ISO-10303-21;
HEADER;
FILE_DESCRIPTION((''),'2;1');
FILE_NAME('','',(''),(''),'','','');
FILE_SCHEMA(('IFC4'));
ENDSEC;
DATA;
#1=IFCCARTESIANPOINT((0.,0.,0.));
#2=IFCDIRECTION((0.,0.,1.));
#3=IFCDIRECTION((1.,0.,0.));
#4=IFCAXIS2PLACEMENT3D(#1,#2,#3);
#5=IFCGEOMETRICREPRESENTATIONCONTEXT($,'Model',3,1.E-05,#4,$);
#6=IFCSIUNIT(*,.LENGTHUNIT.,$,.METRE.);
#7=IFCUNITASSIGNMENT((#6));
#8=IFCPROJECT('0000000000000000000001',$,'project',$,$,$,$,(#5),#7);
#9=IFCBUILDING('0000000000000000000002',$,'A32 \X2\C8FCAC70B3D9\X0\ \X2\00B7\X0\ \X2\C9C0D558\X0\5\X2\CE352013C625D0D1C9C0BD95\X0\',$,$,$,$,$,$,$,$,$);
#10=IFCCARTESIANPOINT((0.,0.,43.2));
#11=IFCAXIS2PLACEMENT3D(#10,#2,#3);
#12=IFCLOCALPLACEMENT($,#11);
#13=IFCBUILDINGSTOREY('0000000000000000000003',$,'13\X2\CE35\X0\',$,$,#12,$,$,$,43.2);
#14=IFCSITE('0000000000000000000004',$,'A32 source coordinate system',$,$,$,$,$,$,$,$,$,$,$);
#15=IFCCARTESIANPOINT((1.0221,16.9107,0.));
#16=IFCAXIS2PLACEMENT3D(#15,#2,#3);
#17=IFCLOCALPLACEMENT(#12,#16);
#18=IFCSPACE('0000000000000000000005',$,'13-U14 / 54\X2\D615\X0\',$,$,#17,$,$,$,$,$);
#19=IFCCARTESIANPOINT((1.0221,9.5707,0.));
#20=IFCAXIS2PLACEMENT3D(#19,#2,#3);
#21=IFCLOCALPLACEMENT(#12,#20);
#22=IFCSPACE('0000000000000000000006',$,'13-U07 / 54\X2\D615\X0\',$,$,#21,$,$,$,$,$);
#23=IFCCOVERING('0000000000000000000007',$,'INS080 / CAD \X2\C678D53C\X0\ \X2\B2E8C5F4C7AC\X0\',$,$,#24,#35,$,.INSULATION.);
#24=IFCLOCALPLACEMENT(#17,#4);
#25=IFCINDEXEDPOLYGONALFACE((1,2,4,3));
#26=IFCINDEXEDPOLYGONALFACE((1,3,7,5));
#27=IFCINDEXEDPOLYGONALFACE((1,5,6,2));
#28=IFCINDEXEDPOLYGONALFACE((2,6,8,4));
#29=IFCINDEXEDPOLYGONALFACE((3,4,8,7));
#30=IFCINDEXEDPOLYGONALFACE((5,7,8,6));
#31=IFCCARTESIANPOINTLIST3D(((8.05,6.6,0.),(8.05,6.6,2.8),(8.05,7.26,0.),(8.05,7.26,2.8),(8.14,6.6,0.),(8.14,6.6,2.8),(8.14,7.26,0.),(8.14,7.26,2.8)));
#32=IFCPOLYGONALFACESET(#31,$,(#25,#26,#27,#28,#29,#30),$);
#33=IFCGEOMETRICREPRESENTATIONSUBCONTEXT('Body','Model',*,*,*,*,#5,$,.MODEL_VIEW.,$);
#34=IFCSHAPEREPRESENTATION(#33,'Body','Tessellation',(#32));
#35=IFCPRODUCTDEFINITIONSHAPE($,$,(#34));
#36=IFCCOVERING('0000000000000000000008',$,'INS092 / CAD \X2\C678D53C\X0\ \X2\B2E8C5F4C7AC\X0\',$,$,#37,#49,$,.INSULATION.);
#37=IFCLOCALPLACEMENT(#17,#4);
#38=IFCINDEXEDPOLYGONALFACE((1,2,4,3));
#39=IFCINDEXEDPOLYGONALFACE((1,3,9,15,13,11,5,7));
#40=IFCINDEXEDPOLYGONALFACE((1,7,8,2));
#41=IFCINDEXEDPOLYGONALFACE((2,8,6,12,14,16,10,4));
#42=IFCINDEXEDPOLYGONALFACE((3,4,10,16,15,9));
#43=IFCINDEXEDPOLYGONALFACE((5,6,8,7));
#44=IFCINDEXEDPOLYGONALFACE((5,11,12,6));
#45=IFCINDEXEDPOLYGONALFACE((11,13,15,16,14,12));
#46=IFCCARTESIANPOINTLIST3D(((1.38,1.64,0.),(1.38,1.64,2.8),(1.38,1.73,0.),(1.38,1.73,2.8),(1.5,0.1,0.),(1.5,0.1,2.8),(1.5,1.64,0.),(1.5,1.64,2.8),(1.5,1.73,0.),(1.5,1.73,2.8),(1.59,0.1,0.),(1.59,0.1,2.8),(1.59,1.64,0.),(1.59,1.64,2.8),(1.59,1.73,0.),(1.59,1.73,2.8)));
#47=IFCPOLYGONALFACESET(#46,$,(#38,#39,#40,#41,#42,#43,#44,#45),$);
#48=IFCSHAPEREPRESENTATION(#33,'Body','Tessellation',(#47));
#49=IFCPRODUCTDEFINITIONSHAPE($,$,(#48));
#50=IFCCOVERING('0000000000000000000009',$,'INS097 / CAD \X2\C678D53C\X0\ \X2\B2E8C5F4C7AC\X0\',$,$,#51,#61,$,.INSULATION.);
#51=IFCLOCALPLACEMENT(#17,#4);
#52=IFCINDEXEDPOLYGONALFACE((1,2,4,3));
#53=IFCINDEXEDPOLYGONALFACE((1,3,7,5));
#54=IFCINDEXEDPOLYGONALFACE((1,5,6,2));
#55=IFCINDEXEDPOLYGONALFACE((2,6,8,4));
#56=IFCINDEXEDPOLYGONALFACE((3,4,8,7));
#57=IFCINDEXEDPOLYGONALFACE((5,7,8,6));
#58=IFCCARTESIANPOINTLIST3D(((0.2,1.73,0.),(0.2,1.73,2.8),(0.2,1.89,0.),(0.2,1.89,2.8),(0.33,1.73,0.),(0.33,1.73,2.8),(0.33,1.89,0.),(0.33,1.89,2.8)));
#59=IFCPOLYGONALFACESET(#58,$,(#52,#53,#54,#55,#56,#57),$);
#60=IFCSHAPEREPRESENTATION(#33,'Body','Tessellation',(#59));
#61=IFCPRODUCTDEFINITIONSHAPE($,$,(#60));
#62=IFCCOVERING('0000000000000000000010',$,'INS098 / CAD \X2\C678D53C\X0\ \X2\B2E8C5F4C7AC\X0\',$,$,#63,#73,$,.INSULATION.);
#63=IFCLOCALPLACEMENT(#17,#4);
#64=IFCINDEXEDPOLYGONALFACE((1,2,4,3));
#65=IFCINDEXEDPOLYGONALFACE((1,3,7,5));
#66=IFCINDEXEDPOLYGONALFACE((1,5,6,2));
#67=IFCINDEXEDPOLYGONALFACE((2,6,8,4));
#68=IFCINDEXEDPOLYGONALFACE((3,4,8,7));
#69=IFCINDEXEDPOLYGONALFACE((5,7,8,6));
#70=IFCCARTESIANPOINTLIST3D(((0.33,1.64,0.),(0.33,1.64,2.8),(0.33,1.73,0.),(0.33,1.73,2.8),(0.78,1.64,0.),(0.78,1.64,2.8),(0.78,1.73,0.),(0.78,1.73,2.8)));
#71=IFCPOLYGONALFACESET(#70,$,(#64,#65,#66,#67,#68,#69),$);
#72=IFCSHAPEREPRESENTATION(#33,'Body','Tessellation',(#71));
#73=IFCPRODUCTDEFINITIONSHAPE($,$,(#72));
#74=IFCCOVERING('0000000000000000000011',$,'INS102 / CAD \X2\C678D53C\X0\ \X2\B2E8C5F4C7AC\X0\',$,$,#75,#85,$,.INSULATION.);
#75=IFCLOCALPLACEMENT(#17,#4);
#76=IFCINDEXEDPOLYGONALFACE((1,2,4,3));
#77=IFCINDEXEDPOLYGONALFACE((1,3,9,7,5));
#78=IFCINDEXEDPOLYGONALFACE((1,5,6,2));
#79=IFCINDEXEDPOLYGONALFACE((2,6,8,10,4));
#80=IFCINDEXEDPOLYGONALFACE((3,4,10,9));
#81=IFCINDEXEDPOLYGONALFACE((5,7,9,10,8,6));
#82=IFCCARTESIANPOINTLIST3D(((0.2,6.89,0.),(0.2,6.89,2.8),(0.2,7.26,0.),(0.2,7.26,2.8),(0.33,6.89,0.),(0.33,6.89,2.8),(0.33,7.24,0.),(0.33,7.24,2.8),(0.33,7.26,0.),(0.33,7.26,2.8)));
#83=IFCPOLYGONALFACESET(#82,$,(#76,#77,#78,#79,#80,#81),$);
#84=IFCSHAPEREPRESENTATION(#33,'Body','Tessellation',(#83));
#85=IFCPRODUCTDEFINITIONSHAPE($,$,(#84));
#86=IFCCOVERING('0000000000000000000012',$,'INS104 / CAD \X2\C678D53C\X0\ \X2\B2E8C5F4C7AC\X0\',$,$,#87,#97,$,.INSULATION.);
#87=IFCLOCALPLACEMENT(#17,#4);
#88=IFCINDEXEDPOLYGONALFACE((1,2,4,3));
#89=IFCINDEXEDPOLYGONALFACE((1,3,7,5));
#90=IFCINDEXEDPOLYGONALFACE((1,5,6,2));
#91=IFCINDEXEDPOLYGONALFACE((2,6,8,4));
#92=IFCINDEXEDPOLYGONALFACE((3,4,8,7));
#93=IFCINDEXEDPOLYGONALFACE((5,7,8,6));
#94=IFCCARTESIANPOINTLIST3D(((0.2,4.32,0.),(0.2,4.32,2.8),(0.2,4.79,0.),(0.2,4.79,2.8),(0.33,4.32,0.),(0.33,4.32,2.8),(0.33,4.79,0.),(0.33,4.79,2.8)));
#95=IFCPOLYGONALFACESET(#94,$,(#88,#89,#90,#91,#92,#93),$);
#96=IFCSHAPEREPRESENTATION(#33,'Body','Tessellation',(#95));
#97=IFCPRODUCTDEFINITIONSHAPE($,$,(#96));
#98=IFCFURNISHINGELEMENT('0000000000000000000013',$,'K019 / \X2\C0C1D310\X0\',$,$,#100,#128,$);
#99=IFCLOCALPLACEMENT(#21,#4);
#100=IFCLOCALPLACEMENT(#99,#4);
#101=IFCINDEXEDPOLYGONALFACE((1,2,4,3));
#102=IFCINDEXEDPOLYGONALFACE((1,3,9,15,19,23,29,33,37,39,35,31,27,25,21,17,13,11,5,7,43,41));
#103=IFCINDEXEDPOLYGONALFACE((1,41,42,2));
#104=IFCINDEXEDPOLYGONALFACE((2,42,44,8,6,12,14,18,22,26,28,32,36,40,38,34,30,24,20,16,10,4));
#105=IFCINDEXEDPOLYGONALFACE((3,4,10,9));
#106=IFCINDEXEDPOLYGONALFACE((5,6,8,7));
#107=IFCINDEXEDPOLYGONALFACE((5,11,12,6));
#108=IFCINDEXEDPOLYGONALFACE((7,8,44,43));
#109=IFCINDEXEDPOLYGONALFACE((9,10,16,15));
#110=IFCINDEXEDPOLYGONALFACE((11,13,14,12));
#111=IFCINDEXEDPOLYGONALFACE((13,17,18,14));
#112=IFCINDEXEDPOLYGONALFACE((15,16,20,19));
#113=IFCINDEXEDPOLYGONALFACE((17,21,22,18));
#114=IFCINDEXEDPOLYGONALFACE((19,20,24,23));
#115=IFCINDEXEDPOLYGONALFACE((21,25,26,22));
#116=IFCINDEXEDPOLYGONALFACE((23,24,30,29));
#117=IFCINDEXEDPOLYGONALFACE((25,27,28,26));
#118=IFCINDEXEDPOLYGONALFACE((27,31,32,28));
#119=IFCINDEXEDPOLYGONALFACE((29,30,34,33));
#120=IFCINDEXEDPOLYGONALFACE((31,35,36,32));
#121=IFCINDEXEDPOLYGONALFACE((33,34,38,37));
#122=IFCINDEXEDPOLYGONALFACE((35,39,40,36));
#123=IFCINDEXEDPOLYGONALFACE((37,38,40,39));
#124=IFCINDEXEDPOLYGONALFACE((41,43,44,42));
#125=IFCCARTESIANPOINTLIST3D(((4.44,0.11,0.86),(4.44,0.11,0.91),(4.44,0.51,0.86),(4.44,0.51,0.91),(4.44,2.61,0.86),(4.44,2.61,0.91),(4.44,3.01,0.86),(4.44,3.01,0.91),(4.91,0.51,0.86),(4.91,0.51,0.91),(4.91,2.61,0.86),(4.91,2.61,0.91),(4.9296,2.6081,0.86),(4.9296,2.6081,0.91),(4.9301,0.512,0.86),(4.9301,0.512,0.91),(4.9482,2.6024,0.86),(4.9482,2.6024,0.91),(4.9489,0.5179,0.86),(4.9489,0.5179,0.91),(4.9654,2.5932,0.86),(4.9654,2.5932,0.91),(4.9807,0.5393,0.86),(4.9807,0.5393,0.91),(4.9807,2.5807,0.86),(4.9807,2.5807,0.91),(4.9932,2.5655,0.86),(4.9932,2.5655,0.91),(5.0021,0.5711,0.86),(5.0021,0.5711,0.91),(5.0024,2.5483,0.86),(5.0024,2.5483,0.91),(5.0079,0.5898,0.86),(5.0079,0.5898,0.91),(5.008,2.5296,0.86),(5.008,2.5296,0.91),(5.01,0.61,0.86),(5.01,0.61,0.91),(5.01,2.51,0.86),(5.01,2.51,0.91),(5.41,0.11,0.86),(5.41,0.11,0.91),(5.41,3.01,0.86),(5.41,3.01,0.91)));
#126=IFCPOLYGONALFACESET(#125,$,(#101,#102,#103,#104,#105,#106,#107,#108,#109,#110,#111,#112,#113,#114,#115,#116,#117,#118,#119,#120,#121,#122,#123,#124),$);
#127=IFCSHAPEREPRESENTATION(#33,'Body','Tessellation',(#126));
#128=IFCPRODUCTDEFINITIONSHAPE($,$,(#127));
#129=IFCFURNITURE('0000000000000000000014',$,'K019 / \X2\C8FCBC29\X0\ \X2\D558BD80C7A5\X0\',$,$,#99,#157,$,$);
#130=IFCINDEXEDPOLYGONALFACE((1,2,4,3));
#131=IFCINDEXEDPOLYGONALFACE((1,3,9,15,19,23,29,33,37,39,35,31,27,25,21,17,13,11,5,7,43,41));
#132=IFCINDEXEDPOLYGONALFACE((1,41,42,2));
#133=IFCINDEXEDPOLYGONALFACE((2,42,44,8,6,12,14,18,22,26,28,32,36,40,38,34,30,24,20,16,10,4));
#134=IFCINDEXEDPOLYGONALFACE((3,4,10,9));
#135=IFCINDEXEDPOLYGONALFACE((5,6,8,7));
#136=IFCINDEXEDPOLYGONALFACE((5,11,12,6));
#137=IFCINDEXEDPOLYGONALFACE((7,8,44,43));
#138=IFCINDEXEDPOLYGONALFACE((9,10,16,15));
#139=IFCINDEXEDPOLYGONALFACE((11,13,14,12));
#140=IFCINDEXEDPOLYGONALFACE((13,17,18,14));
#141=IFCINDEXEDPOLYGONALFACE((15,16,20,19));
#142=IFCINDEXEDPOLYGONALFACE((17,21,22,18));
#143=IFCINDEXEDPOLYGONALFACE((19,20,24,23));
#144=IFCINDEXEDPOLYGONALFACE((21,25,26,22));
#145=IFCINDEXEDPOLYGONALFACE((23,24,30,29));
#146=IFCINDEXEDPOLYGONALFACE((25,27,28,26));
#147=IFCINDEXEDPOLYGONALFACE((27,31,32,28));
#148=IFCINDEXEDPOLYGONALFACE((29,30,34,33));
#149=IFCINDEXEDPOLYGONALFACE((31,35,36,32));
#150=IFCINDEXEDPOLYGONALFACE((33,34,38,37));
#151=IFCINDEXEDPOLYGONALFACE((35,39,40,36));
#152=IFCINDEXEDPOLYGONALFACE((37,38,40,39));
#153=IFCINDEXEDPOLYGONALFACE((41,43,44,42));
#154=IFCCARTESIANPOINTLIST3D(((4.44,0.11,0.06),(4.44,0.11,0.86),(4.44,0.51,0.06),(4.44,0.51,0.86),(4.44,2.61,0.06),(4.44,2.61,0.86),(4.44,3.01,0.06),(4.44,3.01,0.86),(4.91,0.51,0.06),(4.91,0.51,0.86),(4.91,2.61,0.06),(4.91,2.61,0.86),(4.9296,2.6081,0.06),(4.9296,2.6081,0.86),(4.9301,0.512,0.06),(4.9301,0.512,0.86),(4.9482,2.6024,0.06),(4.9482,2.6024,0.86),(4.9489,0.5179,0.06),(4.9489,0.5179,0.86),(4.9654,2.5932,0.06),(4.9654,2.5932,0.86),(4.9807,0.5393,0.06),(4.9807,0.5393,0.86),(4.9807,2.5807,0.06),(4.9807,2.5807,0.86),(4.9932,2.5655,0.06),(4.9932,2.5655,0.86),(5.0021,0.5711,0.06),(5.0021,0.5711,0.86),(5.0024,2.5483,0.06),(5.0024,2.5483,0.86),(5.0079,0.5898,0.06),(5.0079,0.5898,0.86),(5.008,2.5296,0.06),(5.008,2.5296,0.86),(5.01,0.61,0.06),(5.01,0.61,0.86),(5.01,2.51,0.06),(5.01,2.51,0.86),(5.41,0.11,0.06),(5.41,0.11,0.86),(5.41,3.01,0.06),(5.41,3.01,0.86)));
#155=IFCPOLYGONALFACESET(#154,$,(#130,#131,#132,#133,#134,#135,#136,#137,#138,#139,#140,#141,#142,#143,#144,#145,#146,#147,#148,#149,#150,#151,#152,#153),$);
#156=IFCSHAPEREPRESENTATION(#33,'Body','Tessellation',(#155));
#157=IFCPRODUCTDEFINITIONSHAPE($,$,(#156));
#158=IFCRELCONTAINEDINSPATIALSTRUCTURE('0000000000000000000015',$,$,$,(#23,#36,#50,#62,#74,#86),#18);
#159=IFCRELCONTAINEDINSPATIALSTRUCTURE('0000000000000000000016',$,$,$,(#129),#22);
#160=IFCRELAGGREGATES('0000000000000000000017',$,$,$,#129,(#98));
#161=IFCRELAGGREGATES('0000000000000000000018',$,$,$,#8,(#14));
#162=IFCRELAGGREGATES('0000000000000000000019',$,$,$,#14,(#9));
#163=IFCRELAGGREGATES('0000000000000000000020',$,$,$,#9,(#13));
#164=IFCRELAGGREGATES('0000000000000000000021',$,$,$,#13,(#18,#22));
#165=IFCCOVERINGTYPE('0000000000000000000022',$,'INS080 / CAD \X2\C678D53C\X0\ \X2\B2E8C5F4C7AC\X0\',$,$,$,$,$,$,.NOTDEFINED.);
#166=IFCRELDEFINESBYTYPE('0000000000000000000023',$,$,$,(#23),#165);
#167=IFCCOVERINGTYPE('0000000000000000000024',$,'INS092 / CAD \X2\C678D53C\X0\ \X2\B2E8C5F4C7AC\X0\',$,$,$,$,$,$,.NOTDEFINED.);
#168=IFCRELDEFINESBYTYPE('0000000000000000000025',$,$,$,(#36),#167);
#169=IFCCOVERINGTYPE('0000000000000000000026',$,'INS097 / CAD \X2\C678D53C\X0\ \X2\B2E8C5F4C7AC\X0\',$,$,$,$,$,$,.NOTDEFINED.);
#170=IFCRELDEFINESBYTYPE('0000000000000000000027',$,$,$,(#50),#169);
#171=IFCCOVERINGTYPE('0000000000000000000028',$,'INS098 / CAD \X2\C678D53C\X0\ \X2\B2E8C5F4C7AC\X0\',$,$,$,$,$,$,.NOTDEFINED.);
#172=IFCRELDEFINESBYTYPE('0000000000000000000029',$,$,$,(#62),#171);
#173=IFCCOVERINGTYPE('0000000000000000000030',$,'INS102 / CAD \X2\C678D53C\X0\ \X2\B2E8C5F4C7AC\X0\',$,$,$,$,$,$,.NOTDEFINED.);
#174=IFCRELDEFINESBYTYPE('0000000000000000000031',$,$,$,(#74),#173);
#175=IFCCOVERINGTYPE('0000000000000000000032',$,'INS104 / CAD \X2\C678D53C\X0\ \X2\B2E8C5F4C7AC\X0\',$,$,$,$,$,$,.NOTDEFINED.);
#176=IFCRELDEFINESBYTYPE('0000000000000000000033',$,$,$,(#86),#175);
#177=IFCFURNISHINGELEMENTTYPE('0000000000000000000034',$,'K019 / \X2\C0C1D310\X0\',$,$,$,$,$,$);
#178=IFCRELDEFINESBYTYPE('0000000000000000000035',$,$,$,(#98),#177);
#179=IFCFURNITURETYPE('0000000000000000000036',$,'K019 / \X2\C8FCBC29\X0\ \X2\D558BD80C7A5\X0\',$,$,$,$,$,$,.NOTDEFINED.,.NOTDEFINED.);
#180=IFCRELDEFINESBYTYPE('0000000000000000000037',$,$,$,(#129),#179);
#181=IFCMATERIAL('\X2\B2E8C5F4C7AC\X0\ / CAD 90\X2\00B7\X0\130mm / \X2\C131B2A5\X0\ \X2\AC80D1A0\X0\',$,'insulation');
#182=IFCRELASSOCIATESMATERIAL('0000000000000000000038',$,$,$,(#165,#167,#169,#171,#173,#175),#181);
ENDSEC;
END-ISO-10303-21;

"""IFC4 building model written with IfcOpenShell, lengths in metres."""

from ifc_helpers import new_model, si_unit, frame, origin, origin_with_axes, place, context, subcontext, project, spatial, polyline, outline, extrude, source, transform, mapped, material, type_object, type_shapes, element, aggregate, save


model = new_model("IFC4")

# Units and contexts
model_context = context("Model", 3, precision=1e-05, world=origin_with_axes())
body_context = subcontext(model_context, "Body", "Model", "MODEL_VIEW")
ifc_project = project(units=[si_unit("LENGTHUNIT", "METRE")], contexts=[model_context])

# Site, building, storey, space
storey_placement = place(None, frame((0.0, 0.0, 43.2), z_axis=(0.0, 0.0, 1.0), x_axis=(1.0, 0.0, 0.0)))
space_1_placement = place(storey_placement, frame((1.0221, 16.9107, 0.0), z_axis=(0.0, 0.0, 1.0), x_axis=(1.0, 0.0, 0.0)))
site = spatial("IfcSite", under=ifc_project, Name="A32 source coordinate system")
building = spatial("IfcBuilding", under=site, Name="A32 주거동 · 지하5층–옥탑지붕")
storey = spatial("IfcBuildingStorey", under=building, at=storey_placement, Name="13층", Elevation=43.2)
space_1 = spatial("IfcSpace", under=storey, at=space_1_placement, Name="13-U14 / 54형")

# Coverings
ifc_material = material(Name="단열재 / CAD 90·130mm / 성능 검토", Category="insulation")
covering_type_1 = type_object("IfcCoveringType", Name="INS080 / CAD 외피 단열재", PredefinedType="NOTDEFINED", material=ifc_material)
shared_shape_1 = source(origin(), body_context, "Body", "SweptSolid", [
    extrude(outline(polyline([(8.14, 7.26), (8.14, 6.6), (8.05, 6.6), (8.05, 7.26), (8.14, 7.26)])), origin(), (0.0, 0.0, 1.0), 2.8),
])
type_shapes(covering_type_1, [shared_shape_1])
covering_1_placement = place(space_1_placement, origin_with_axes())
element("IfcCovering", 1, at=covering_1_placement, inside=space_1, type_object=covering_type_1, Name="INS080 / CAD 외피 단열재", PredefinedType="INSULATION", context=body_context, shape_type="MappedRepresentation", body=[
    mapped(shared_shape_1, transform((0.0, 0.0, 0.0), scale=1.0)),
])
covering_type_2 = type_object("IfcCoveringType", Name="INS092 / CAD 외피 단열재", PredefinedType="NOTDEFINED", material=ifc_material)
shared_shape_2 = source(origin(), body_context, "Body", "SweptSolid", [
    extrude(outline(polyline([(1.59, 1.73), (1.59, 1.64), (1.59, 0.1), (1.5, 0.1), (1.5, 1.64), (1.38, 1.64), (1.38, 1.73), (1.5, 1.73), (1.59, 1.73)])), origin(), (0.0, 0.0, 1.0), 2.8),
])
type_shapes(covering_type_2, [shared_shape_2])
covering_2_placement = place(space_1_placement, origin_with_axes())
element("IfcCovering", 2, at=covering_2_placement, inside=space_1, type_object=covering_type_2, Name="INS092 / CAD 외피 단열재", PredefinedType="INSULATION", context=body_context, shape_type="MappedRepresentation", body=[
    mapped(shared_shape_2, transform((0.0, 0.0, 0.0), scale=1.0)),
])
covering_type_3 = type_object("IfcCoveringType", Name="INS097 / CAD 외피 단열재", PredefinedType="NOTDEFINED", material=ifc_material)
shared_shape_3 = source(origin(), body_context, "Body", "SweptSolid", [
    extrude(outline(polyline([(0.33, 1.89), (0.33, 1.73), (0.2, 1.73), (0.2, 1.89), (0.33, 1.89)])), origin(), (0.0, 0.0, 1.0), 2.8),
])
type_shapes(covering_type_3, [shared_shape_3])
covering_3_placement = place(space_1_placement, origin_with_axes())
element("IfcCovering", 3, at=covering_3_placement, inside=space_1, type_object=covering_type_3, Name="INS097 / CAD 외피 단열재", PredefinedType="INSULATION", context=body_context, shape_type="MappedRepresentation", body=[
    mapped(shared_shape_3, transform((0.0, 0.0, 0.0), scale=1.0)),
])
covering_type_4 = type_object("IfcCoveringType", Name="INS098 / CAD 외피 단열재", PredefinedType="NOTDEFINED", material=ifc_material)
shared_shape_4 = source(origin(), body_context, "Body", "SweptSolid", [
    extrude(outline(polyline([(0.78, 1.73), (0.78, 1.64), (0.33, 1.64), (0.33, 1.73), (0.78, 1.73)])), origin(), (0.0, 0.0, 1.0), 2.8),
])
type_shapes(covering_type_4, [shared_shape_4])
covering_4_placement = place(space_1_placement, origin_with_axes())
element("IfcCovering", 4, at=covering_4_placement, inside=space_1, type_object=covering_type_4, Name="INS098 / CAD 외피 단열재", PredefinedType="INSULATION", context=body_context, shape_type="MappedRepresentation", body=[
    mapped(shared_shape_4, transform((0.0, 0.0, 0.0), scale=1.0)),
])
covering_type_5 = type_object("IfcCoveringType", Name="INS102 / CAD 외피 단열재", PredefinedType="NOTDEFINED", material=ifc_material)
shared_shape_5 = source(origin(), body_context, "Body", "SweptSolid", [
    extrude(outline(polyline([(0.33, 7.26), (0.33, 7.24), (0.33, 6.89), (0.2, 6.89), (0.2, 7.26), (0.33, 7.26)])), origin(), (0.0, 0.0, 1.0), 2.8),
])
type_shapes(covering_type_5, [shared_shape_5])
covering_5_placement = place(space_1_placement, origin_with_axes())
element("IfcCovering", 5, at=covering_5_placement, inside=space_1, type_object=covering_type_5, Name="INS102 / CAD 외피 단열재", PredefinedType="INSULATION", context=body_context, shape_type="MappedRepresentation", body=[
    mapped(shared_shape_5, transform((0.0, 0.0, 0.0), scale=1.0)),
])
covering_type_6 = type_object("IfcCoveringType", Name="INS104 / CAD 외피 단열재", PredefinedType="NOTDEFINED", material=ifc_material)
shared_shape_6 = source(origin(), body_context, "Body", "SweptSolid", [
    extrude(outline(polyline([(0.33, 4.32), (0.2, 4.32), (0.2, 4.79), (0.33, 4.79), (0.33, 4.32)])), origin(), (0.0, 0.0, 1.0), 2.8),
])
type_shapes(covering_type_6, [shared_shape_6])
covering_6_placement = place(space_1_placement, origin_with_axes())
element("IfcCovering", 6, at=covering_6_placement, inside=space_1, type_object=covering_type_6, Name="INS104 / CAD 외피 단열재", PredefinedType="INSULATION", context=body_context, shape_type="MappedRepresentation", body=[
    mapped(shared_shape_6, transform((0.0, 0.0, 0.0), scale=1.0)),
])

# Furnishing element
furnishing_element_type = type_object("IfcFurnishingElementType", Name="K019 / 상판")
shared_shape_7 = source(origin(), body_context, "Body", "SweptSolid", [
    extrude(outline(polyline([(4.91, 0.51), (4.9301, 0.512), (4.9489, 0.5179), (4.9807, 0.5393), (5.0021, 0.5711), (5.0079, 0.5898), (5.01, 0.61), (5.01, 2.51), (5.008, 2.5296), (5.0024, 2.5483), (4.9932, 2.5655), (4.9807, 2.5807), (4.9654, 2.5932), (4.9482, 2.6024), (4.9296, 2.6081), (4.91, 2.61), (4.44, 2.61), (4.44, 3.01), (5.41, 3.01), (5.41, 0.11), (4.44, 0.11), (4.44, 0.51), (4.91, 0.51)])), frame((0.0, 0.0, 0.86)), (0.0, 0.0, 1.0), 0.05),
])
type_shapes(furnishing_element_type, [shared_shape_7])
space_2_placement = place(storey_placement, frame((1.0221, 9.5707, 0.0), z_axis=(0.0, 0.0, 1.0), x_axis=(1.0, 0.0, 0.0)))
furniture_placement = place(space_2_placement, origin_with_axes())
furnishing_placement = place(furniture_placement, origin_with_axes())
furnishing = element("IfcFurnishingElement", 7, at=furnishing_placement, type_object=furnishing_element_type, Name="K019 / 상판", context=body_context, shape_type="MappedRepresentation", body=[
    mapped(shared_shape_7, transform((0.0, 0.0, 0.0), scale=1.0)),
])

# Shared definitions
space_2 = spatial("IfcSpace", under=storey, at=space_2_placement, Name="13-U07 / 54형")

# Furniture
furniture_type = type_object("IfcFurnitureType", Name="K019 / 주방 하부장", AssemblyPlace="NOTDEFINED", PredefinedType="NOTDEFINED")
shared_shape_8 = source(origin(), body_context, "Body", "SweptSolid", [
    extrude(outline(polyline([(4.44, 0.51), (4.91, 0.51), (4.9301, 0.512), (4.9489, 0.5179), (4.9807, 0.5393), (5.0021, 0.5711), (5.0079, 0.5898), (5.01, 0.61), (5.01, 2.51), (5.008, 2.5296), (5.0024, 2.5483), (4.9932, 2.5655), (4.9807, 2.5807), (4.9654, 2.5932), (4.9482, 2.6024), (4.9296, 2.6081), (4.91, 2.61), (4.44, 2.61), (4.44, 3.01), (5.41, 3.01), (5.41, 0.11), (4.44, 0.11), (4.44, 0.51)])), frame((0.0, 0.0, 0.06)), (0.0, 0.0, 1.0), 0.8),
])
type_shapes(furniture_type, [shared_shape_8])
furniture = element("IfcFurniture", 8, at=furniture_placement, inside=space_2, type_object=furniture_type, Name="K019 / 주방 하부장", context=body_context, shape_type="MappedRepresentation", body=[
    mapped(shared_shape_8, transform((0.0, 0.0, 0.0), scale=1.0)),
])
aggregate(furniture, [furnishing])

save(model, "model.ifc")
